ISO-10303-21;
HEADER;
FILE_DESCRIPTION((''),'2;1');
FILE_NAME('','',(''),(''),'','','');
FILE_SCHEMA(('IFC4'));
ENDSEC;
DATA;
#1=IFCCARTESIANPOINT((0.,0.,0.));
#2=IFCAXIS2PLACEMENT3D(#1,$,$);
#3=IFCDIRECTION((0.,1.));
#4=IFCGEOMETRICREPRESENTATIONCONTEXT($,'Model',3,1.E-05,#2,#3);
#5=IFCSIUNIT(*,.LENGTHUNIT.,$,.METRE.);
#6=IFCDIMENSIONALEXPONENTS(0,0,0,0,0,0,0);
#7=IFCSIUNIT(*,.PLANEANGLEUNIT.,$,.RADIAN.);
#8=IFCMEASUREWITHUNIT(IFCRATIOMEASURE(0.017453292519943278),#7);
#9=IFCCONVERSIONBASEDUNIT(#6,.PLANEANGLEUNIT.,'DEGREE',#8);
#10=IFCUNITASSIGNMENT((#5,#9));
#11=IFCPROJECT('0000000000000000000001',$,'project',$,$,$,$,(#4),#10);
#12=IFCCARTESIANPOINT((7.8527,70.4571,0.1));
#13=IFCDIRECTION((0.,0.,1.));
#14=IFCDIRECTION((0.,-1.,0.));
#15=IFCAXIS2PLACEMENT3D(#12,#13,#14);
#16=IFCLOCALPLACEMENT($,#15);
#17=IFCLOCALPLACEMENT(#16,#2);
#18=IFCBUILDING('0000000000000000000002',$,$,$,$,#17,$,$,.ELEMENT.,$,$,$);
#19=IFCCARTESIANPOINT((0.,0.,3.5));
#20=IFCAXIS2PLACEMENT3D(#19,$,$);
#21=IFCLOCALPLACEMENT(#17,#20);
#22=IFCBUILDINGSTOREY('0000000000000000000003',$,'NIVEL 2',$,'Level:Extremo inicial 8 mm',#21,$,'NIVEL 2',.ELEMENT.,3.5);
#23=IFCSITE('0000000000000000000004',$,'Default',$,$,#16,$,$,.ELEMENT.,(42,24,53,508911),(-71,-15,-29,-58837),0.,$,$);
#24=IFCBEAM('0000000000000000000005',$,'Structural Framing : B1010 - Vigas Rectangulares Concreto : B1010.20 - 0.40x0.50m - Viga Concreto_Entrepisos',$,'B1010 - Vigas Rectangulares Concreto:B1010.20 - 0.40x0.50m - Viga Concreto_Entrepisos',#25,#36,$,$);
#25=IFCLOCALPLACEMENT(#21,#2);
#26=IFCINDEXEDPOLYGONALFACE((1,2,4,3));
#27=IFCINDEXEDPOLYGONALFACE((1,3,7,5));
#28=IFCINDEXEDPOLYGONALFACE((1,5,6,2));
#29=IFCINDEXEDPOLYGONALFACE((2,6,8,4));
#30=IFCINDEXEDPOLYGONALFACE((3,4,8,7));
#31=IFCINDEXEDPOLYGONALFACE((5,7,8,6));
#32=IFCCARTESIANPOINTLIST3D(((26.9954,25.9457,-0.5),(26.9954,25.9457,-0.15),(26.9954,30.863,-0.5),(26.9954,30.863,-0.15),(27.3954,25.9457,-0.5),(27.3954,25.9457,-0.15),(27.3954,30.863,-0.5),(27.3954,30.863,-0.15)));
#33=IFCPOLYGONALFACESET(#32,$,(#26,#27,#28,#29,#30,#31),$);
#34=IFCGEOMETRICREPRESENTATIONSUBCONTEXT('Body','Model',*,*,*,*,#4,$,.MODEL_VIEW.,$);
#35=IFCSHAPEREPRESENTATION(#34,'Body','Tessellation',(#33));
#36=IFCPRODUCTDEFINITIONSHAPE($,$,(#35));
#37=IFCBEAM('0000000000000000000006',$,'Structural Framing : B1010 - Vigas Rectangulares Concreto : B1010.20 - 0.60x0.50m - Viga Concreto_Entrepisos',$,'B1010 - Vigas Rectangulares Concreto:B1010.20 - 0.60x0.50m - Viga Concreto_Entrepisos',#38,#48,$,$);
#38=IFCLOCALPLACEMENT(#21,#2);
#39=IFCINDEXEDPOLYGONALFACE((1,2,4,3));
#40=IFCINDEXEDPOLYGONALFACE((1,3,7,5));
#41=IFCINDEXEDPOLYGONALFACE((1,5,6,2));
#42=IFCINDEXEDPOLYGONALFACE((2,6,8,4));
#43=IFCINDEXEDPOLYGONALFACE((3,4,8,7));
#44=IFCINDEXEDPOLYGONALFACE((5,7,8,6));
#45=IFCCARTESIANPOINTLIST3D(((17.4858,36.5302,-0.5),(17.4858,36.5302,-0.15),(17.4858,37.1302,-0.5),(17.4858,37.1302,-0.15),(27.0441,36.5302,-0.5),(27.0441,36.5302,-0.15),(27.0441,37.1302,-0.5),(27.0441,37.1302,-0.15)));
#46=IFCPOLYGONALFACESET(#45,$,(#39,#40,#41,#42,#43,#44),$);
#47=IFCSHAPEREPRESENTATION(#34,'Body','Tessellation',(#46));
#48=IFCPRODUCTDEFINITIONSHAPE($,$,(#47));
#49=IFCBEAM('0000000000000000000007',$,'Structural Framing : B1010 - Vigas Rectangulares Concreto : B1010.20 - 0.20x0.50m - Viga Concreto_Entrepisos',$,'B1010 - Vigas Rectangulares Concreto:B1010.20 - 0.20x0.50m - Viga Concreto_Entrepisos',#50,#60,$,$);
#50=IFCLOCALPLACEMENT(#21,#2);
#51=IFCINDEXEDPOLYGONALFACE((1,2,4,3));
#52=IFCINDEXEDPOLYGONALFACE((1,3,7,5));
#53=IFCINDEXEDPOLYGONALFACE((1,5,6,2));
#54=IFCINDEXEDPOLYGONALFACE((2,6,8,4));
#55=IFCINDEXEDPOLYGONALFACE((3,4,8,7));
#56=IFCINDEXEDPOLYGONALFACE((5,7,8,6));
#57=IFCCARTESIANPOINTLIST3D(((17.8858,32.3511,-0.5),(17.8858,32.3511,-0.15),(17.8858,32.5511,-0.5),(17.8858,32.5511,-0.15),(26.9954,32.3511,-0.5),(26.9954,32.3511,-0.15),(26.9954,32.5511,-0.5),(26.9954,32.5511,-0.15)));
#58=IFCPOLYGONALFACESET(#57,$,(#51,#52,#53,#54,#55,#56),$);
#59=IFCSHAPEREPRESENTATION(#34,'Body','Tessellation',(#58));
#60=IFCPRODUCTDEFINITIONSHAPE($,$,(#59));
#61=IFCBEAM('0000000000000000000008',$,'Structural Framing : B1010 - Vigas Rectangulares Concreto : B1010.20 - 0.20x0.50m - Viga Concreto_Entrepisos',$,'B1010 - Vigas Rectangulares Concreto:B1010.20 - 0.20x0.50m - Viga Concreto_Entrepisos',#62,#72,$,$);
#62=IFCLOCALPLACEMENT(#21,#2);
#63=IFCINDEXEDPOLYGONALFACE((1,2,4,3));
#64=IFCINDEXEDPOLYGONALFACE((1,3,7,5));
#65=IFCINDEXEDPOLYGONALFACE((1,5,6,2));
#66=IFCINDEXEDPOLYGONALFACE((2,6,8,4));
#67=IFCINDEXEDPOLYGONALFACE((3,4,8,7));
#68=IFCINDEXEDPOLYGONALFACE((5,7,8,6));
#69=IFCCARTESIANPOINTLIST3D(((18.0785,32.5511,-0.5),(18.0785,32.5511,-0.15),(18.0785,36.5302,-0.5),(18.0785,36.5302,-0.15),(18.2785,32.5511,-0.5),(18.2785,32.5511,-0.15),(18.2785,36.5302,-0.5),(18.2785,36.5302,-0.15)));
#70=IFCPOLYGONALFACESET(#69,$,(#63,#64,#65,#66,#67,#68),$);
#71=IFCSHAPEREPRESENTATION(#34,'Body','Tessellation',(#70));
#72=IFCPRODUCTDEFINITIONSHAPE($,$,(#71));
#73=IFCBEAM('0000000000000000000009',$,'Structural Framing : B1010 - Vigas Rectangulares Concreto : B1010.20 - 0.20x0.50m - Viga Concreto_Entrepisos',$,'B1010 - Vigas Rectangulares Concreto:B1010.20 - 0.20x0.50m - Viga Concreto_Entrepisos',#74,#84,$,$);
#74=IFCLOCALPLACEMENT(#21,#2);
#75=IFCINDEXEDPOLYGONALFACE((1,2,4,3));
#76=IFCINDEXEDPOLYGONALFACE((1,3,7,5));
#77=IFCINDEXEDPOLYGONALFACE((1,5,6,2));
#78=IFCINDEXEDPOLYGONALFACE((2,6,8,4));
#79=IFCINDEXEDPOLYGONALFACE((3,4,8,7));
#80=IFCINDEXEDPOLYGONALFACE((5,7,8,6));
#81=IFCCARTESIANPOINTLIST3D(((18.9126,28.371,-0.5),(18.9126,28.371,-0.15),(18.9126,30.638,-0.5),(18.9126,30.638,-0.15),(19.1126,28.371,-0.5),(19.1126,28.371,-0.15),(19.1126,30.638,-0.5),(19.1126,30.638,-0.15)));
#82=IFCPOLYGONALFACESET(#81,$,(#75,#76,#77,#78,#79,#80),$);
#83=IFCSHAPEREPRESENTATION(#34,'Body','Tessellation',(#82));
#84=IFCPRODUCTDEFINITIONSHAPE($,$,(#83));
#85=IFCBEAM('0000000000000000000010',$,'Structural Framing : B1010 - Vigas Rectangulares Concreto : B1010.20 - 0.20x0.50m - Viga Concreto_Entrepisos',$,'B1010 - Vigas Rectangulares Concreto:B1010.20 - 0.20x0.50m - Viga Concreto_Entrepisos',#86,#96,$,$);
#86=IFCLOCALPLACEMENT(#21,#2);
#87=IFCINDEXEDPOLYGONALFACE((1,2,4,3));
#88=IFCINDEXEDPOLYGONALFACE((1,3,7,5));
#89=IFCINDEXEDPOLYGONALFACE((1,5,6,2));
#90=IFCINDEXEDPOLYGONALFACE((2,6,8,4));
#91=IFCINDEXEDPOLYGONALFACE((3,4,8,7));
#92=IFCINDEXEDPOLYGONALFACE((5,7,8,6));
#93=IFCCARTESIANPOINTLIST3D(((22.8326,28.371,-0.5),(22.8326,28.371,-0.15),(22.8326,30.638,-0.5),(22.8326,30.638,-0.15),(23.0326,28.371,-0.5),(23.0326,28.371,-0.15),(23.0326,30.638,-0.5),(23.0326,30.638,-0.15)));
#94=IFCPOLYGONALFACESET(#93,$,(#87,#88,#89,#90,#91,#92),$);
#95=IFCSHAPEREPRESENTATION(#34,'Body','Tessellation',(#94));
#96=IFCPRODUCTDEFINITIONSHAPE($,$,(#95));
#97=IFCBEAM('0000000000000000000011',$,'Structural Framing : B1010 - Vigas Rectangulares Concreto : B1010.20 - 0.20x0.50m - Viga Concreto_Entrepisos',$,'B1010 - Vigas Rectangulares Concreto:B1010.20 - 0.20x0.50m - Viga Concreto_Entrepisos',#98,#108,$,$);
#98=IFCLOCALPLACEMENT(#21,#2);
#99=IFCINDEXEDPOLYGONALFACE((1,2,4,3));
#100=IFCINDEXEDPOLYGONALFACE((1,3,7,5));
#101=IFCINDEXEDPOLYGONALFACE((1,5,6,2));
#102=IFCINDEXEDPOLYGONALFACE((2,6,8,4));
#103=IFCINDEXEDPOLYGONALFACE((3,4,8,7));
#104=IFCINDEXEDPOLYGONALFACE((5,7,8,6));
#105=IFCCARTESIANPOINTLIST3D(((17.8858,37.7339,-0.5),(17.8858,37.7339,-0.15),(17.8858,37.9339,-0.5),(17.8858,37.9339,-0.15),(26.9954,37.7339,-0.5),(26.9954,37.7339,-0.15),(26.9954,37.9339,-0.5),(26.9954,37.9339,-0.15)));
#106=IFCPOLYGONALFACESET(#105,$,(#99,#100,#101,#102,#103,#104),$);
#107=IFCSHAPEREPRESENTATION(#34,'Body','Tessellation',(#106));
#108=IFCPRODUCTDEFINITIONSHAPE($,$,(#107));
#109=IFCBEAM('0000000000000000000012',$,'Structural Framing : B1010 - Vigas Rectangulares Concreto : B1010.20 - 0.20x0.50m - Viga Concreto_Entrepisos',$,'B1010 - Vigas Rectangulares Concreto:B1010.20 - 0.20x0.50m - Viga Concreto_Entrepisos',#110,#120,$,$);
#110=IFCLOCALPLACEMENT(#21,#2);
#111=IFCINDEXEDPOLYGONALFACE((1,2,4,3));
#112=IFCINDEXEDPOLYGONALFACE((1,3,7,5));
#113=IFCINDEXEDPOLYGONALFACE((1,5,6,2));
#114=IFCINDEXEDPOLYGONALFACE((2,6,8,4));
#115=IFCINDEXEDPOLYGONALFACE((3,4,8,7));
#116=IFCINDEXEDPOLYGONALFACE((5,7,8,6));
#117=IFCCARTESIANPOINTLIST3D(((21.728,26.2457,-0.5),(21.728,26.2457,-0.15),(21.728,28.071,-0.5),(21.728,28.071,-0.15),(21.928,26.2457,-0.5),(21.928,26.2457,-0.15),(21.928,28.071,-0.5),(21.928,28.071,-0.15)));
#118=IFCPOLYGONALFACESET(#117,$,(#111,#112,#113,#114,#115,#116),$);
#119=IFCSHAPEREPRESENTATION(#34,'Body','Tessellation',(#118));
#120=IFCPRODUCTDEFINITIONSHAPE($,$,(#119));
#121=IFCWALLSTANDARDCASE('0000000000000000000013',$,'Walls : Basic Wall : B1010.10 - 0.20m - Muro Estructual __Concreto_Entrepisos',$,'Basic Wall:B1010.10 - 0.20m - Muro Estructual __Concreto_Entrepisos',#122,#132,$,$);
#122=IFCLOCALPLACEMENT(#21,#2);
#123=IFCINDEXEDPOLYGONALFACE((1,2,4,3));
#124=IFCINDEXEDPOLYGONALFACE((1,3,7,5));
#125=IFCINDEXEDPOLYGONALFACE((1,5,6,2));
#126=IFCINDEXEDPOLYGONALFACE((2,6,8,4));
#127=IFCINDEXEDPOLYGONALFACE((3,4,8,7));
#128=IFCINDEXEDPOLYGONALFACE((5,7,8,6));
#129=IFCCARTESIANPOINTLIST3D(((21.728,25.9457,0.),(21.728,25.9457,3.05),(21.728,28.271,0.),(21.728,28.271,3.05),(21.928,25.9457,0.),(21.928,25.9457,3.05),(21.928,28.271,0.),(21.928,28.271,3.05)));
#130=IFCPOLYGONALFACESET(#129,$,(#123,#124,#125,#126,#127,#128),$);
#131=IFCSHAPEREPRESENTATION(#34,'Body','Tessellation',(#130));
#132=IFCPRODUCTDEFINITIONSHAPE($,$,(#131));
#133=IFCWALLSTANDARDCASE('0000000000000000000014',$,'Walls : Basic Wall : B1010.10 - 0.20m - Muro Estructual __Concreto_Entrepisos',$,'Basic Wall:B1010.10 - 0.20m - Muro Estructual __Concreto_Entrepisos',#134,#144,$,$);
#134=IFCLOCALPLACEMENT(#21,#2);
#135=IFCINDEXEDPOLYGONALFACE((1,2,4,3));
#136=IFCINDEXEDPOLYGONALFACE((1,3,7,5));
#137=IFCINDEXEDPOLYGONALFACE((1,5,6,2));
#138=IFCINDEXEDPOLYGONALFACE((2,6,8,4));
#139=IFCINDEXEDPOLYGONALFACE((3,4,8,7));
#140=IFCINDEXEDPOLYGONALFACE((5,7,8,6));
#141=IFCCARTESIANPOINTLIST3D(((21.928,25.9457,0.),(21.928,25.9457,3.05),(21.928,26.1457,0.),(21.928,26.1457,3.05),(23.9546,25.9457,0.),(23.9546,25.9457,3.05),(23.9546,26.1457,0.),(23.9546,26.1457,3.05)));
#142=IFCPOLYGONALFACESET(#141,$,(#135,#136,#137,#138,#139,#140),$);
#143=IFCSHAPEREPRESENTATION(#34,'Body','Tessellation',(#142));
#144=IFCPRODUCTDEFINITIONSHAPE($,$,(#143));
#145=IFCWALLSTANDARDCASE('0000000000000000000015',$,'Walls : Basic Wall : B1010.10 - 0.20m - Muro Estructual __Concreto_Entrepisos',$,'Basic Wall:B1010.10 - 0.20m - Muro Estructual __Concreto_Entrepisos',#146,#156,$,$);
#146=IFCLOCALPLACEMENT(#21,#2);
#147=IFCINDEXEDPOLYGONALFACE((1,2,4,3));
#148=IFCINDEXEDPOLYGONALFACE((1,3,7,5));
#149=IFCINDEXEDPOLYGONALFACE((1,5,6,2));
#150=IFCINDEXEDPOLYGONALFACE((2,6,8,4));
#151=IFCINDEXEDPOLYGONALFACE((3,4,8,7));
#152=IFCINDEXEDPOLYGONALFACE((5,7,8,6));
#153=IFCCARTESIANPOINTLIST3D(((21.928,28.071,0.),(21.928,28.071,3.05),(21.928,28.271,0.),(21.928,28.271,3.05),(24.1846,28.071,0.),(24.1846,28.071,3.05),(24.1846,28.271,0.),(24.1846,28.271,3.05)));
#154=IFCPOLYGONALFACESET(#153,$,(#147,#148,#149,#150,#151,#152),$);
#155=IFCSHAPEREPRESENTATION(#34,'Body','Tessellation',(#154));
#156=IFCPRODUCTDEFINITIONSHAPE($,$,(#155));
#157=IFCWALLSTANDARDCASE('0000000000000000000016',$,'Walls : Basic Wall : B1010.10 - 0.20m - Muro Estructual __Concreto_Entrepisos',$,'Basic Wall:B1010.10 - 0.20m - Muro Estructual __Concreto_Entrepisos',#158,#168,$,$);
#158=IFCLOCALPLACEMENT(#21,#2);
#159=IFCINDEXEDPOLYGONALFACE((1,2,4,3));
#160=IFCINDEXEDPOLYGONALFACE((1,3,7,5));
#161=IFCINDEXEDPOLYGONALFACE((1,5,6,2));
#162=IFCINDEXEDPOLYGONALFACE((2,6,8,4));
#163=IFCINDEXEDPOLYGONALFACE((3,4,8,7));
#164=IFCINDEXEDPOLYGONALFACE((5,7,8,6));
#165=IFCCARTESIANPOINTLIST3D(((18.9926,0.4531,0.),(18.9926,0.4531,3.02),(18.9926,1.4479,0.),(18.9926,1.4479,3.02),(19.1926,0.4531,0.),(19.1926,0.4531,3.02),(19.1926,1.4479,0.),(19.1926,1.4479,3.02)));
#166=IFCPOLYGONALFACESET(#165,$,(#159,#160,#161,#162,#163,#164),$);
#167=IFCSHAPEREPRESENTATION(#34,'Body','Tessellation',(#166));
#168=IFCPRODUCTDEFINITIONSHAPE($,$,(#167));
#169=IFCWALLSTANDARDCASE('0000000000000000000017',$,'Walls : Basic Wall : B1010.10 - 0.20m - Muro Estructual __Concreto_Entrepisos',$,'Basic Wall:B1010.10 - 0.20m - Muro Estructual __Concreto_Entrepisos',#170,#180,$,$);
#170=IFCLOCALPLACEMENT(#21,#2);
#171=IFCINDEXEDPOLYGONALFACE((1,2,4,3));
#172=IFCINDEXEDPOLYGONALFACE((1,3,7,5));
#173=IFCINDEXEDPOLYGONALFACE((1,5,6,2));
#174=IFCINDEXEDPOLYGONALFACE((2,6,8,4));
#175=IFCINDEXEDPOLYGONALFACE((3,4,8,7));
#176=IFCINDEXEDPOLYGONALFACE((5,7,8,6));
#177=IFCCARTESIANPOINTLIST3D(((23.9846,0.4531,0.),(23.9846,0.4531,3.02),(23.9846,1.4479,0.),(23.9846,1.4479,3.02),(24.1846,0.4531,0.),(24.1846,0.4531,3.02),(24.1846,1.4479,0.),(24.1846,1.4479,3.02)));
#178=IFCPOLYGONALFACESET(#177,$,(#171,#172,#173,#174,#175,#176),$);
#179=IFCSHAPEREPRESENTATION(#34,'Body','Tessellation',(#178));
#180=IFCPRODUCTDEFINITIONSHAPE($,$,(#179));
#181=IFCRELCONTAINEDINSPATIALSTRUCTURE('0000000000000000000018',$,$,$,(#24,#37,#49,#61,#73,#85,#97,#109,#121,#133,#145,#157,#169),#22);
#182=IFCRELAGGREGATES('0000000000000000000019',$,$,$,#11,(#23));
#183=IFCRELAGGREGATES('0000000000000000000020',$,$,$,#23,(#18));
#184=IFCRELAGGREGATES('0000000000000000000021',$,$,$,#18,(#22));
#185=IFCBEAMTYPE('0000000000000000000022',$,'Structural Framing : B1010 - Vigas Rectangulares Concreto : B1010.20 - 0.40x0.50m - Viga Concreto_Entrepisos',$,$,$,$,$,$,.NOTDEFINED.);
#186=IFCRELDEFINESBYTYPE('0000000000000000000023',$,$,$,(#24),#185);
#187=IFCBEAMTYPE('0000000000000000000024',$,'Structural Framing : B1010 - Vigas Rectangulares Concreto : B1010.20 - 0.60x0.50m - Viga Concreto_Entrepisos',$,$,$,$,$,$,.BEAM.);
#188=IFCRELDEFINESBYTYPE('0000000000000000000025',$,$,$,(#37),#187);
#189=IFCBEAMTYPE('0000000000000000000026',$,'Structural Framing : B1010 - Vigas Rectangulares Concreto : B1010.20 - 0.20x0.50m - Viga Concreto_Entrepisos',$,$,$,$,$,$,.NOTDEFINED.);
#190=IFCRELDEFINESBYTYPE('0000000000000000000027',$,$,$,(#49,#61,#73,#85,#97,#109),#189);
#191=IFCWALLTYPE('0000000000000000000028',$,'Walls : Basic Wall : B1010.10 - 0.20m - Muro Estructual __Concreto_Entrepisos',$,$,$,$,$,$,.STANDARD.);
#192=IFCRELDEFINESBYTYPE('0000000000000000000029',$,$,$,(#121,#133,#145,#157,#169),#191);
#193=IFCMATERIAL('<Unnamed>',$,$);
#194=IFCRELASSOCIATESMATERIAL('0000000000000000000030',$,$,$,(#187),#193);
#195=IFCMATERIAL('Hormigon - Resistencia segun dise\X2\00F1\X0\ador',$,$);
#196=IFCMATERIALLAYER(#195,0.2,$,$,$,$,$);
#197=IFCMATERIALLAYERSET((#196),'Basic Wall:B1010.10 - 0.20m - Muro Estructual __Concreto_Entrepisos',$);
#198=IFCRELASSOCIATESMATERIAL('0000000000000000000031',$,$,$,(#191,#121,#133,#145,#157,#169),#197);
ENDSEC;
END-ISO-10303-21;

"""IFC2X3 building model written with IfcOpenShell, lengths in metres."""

from ifc_helpers import new_model, entity, si_unit, converted_unit, direction, frame, frame_2d, origin, place, context, subcontext, project, spatial, rectangle, extrude, material, layer, layer_set, layer_usage, type_object, element, save


model = new_model("IFC2X3")

# Units and contexts
model_context = context("Model", 3, precision=1e-05, world=origin(), true_north=direction((0.0, 1.0)))
body_context = subcontext(model_context, "Body", "Model", "MODEL_VIEW")
ifc_project = project(units=[si_unit("LENGTHUNIT", "METRE"), converted_unit("PLANEANGLEUNIT", "DEGREE", entity("IfcRatioMeasure", 0.017453292519943278), si_unit("PLANEANGLEUNIT", "RADIAN"), dimensions=[0, 0, 0, 0, 0, 0, 0])], contexts=[model_context])

# Site, building, storey
site_placement = place(None, frame((7.8527, 70.4571, 0.1), z_axis=(0.0, 0.0, 1.0), x_axis=(0.0, -1.0, 0.0)))
site = spatial("IfcSite", under=ifc_project, at=site_placement, Name="Default", CompositionType="ELEMENT", RefLatitude=(42, 24, 53, 508911), RefLongitude=(-71, -15, -29, -58837), RefElevation=0.0)
building_placement = place(site_placement, origin())
building = spatial("IfcBuilding", under=site, at=building_placement, CompositionType="ELEMENT")
storey_placement = place(building_placement, frame((0.0, 0.0, 3.5)))
storey = spatial("IfcBuildingStorey", under=building, at=storey_placement, Name="NIVEL 2", ObjectType="Level:Extremo inicial 8 mm", LongName="NIVEL 2", CompositionType="ELEMENT", Elevation=3.5)

# Beams
beam_type_1 = type_object("IfcBeamType", Name="Structural Framing : B1010 - Vigas Rectangulares Concreto : B1010.20 - 0.40x0.50m - Viga Concreto_Entrepisos", PredefinedType="NOTDEFINED")
beam_1_placement = place(storey_placement, frame((27.1954, 26.0957, 0.0), z_axis=(0.0, 0.0, 1.0), x_axis=(0.0, 1.0, 0.0)))
element("IfcBeam", 1, at=beam_1_placement, inside=storey, type_object=beam_type_1, Name="Structural Framing : B1010 - Vigas Rectangulares Concreto : B1010.20 - 0.40x0.50m - Viga Concreto_Entrepisos", ObjectType="B1010 - Vigas Rectangulares Concreto:B1010.20 - 0.40x0.50m - Viga Concreto_Entrepisos", context=body_context, shape_type="SweptSolid", body=[
    extrude(rectangle(XDim=0.35, YDim=0.4, at=frame_2d((0.0, 0.0), x_axis=(1.0, 0.0))), frame((-0.15, 0.0, -0.325), z_axis=(1.0, 0.0, 0.0), x_axis=(0.0, 0.0, -1.0)), (0.0, 0.0, 1.0), 4.9174),
])
ifc_material_1 = material(Name="<Unnamed>")
beam_type_2 = type_object("IfcBeamType", Name="Structural Framing : B1010 - Vigas Rectangulares Concreto : B1010.20 - 0.60x0.50m - Viga Concreto_Entrepisos", PredefinedType="BEAM", material=ifc_material_1)
beam_2_placement = place(storey_placement, frame((17.4858, 36.8302, 0.0)))
element("IfcBeam", 2, at=beam_2_placement, inside=storey, type_object=beam_type_2, Name="Structural Framing : B1010 - Vigas Rectangulares Concreto : B1010.20 - 0.60x0.50m - Viga Concreto_Entrepisos", ObjectType="B1010 - Vigas Rectangulares Concreto:B1010.20 - 0.60x0.50m - Viga Concreto_Entrepisos", context=body_context, shape_type="SweptSolid", body=[
    extrude(rectangle(XDim=0.35, YDim=0.6, at=frame_2d((0.0, 0.0), x_axis=(1.0, 0.0))), frame((0.0, 0.0, -0.325), z_axis=(1.0, 0.0, 0.0), x_axis=(0.0, 0.0, -1.0)), (0.0, 0.0, 1.0), 9.5583),
])
beam_type_3 = type_object("IfcBeamType", Name="Structural Framing : B1010 - Vigas Rectangulares Concreto : B1010.20 - 0.20x0.50m - Viga Concreto_Entrepisos", PredefinedType="NOTDEFINED")
beam_3_placement = place(storey_placement, frame((17.6858, 32.4511, 0.0)))
element("IfcBeam", 3, at=beam_3_placement, inside=storey, type_object=beam_type_3, Name="Structural Framing : B1010 - Vigas Rectangulares Concreto : B1010.20 - 0.20x0.50m - Viga Concreto_Entrepisos", ObjectType="B1010 - Vigas Rectangulares Concreto:B1010.20 - 0.20x0.50m - Viga Concreto_Entrepisos", context=body_context, shape_type="SweptSolid", body=[
    extrude(rectangle(XDim=0.35, YDim=0.2, at=frame_2d((0.0, 0.0), x_axis=(1.0, 0.0))), frame((0.2, 0.0, -0.325), z_axis=(1.0, 0.0, 0.0), x_axis=(0.0, 0.0, -1.0)), (0.0, 0.0, 1.0), 9.1096),
])
beam_4_placement = place(storey_placement, frame((18.1785, 32.4511, 0.0), z_axis=(0.0, 0.0, 1.0), x_axis=(0.0, 1.0, 0.0)))
element("IfcBeam", 4, at=beam_4_placement, inside=storey, type_object=beam_type_3, Name="Structural Framing : B1010 - Vigas Rectangulares Concreto : B1010.20 - 0.20x0.50m - Viga Concreto_Entrepisos", ObjectType="B1010 - Vigas Rectangulares Concreto:B1010.20 - 0.20x0.50m - Viga Concreto_Entrepisos", context=body_context, shape_type="SweptSolid", body=[
    extrude(rectangle(XDim=0.35, YDim=0.2, at=frame_2d((0.0, 0.0), x_axis=(1.0, 0.0))), frame((0.1, 0.0, -0.325), z_axis=(1.0, 0.0, 0.0), x_axis=(0.0, 0.0, -1.0)), (0.0, 0.0, 1.0), 3.9792),
])
beam_5_placement = place(storey_placement, frame((19.0126, 28.221, 0.0), z_axis=(0.0, 0.0, 1.0), x_axis=(0.0, 1.0, 0.0)))
element("IfcBeam", 5, at=beam_5_placement, inside=storey, type_object=beam_type_3, Name="Structural Framing : B1010 - Vigas Rectangulares Concreto : B1010.20 - 0.20x0.50m - Viga Concreto_Entrepisos", ObjectType="B1010 - Vigas Rectangulares Concreto:B1010.20 - 0.20x0.50m - Viga Concreto_Entrepisos", context=body_context, shape_type="SweptSolid", body=[
    extrude(rectangle(XDim=0.35, YDim=0.2, at=frame_2d((0.0, 0.0), x_axis=(1.0, 0.0))), frame((0.15, 0.0, -0.325), z_axis=(1.0, 0.0, 0.0), x_axis=(0.0, 0.0, -1.0)), (0.0, 0.0, 1.0), 2.2671),
])
beam_6_placement = place(storey_placement, frame((22.9326, 28.171, 0.0), z_axis=(0.0, 0.0, 1.0), x_axis=(0.0, 1.0, 0.0)))
element("IfcBeam", 6, at=beam_6_placement, inside=storey, type_object=beam_type_3, Name="Structural Framing : B1010 - Vigas Rectangulares Concreto : B1010.20 - 0.20x0.50m - Viga Concreto_Entrepisos", ObjectType="B1010 - Vigas Rectangulares Concreto:B1010.20 - 0.20x0.50m - Viga Concreto_Entrepisos", context=body_context, shape_type="SweptSolid", body=[
    extrude(rectangle(XDim=0.35, YDim=0.2, at=frame_2d((0.0, 0.0), x_axis=(1.0, 0.0))), frame((0.2, 0.0, -0.325), z_axis=(1.0, 0.0, 0.0), x_axis=(0.0, 0.0, -1.0)), (0.0, 0.0, 1.0), 2.2671),
])
beam_7_placement = place(storey_placement, frame((17.6858, 37.8339, 0.0)))
element("IfcBeam", 7, at=beam_7_placement, inside=storey, type_object=beam_type_3, Name="Structural Framing : B1010 - Vigas Rectangulares Concreto : B1010.20 - 0.20x0.50m - Viga Concreto_Entrepisos", ObjectType="B1010 - Vigas Rectangulares Concreto:B1010.20 - 0.20x0.50m - Viga Concreto_Entrepisos", context=body_context, shape_type="SweptSolid", body=[
    extrude(rectangle(XDim=0.35, YDim=0.2, at=frame_2d((0.0, 0.0), x_axis=(1.0, 0.0))), frame((0.2, 0.0, -0.325), z_axis=(1.0, 0.0, 0.0), x_axis=(0.0, 0.0, -1.0)), (0.0, 0.0, 1.0), 9.1096),
])
beam_8_placement = place(storey_placement, frame((21.828, 26.0957, 0.0), z_axis=(0.0, 0.0, 1.0), x_axis=(0.0, 1.0, 0.0)))
element("IfcBeam", 8, at=beam_8_placement, inside=storey, type_object=beam_type_3, Name="Structural Framing : B1010 - Vigas Rectangulares Concreto : B1010.20 - 0.20x0.50m - Viga Concreto_Entrepisos", ObjectType="B1010 - Vigas Rectangulares Concreto:B1010.20 - 0.20x0.50m - Viga Concreto_Entrepisos", context=body_context, shape_type="SweptSolid", body=[
    extrude(rectangle(XDim=0.35, YDim=0.2, at=frame_2d((0.0, 0.0), x_axis=(1.0, 0.0))), frame((0.15, 0.0, -0.325), z_axis=(1.0, 0.0, 0.0), x_axis=(0.0, 0.0, -1.0)), (0.0, 0.0, 1.0), 1.8253),
])

# Walls
ifc_material_2 = material(Name="Hormigon - Resistencia segun diseñador")
ifc_layer = layer(ifc_material_2, 0.2)
ifc_layer_set = layer_set([ifc_layer], Name="Basic Wall:B1010.10 - 0.20m - Muro Estructual __Concreto_Entrepisos")
ifc_layer_usage_1 = layer_usage(ifc_layer_set, "AXIS2", "NEGATIVE", 0.1)
wall_type = type_object("IfcWallType", Name="Walls : Basic Wall : B1010.10 - 0.20m - Muro Estructual __Concreto_Entrepisos", PredefinedType="STANDARD", material=ifc_layer_set)
wall_1_placement = place(storey_placement, frame((21.828, 25.9457, 0.0), z_axis=(0.0, 0.0, 1.0), x_axis=(0.0, 1.0, 0.0)))
element("IfcWallStandardCase", 9, at=wall_1_placement, inside=storey, type_object=wall_type, material=ifc_layer_usage_1, Name="Walls : Basic Wall : B1010.10 - 0.20m - Muro Estructual __Concreto_Entrepisos", ObjectType="Basic Wall:B1010.10 - 0.20m - Muro Estructual __Concreto_Entrepisos", context=body_context, shape_type="SweptSolid", body=[
    extrude(rectangle(XDim=2.3253, YDim=0.2, at=frame_2d((1.1626, 0.0), x_axis=(-1.0, 0.0))), origin(), (0.0, 0.0, 1.0), 3.05),
])
ifc_layer_usage_2 = layer_usage(ifc_layer_set, "AXIS2", "NEGATIVE", 0.1)
wall_2_placement = place(storey_placement, frame((21.928, 26.0457, 0.0)))
element("IfcWallStandardCase", 10, at=wall_2_placement, inside=storey, type_object=wall_type, material=ifc_layer_usage_2, Name="Walls : Basic Wall : B1010.10 - 0.20m - Muro Estructual __Concreto_Entrepisos", ObjectType="Basic Wall:B1010.10 - 0.20m - Muro Estructual __Concreto_Entrepisos", context=body_context, shape_type="SweptSolid", body=[
    extrude(rectangle(XDim=2.0266, YDim=0.2, at=frame_2d((1.0133, 0.0), x_axis=(-1.0, 0.0))), origin(), (0.0, 0.0, 1.0), 3.05),
])
ifc_layer_usage_3 = layer_usage(ifc_layer_set, "AXIS2", "NEGATIVE", 0.1)
wall_3_placement = place(storey_placement, frame((21.928, 28.171, 0.0)))
element("IfcWallStandardCase", 11, at=wall_3_placement, inside=storey, type_object=wall_type, material=ifc_layer_usage_3, Name="Walls : Basic Wall : B1010.10 - 0.20m - Muro Estructual __Concreto_Entrepisos", ObjectType="Basic Wall:B1010.10 - 0.20m - Muro Estructual __Concreto_Entrepisos", context=body_context, shape_type="SweptSolid", body=[
    extrude(rectangle(XDim=2.2566, YDim=0.2, at=frame_2d((1.1283, 0.0), x_axis=(-1.0, 0.0))), origin(), (0.0, 0.0, 1.0), 3.05),
])
ifc_layer_usage_4 = layer_usage(ifc_layer_set, "AXIS2", "NEGATIVE", 0.1)
wall_4_placement = place(storey_placement, frame((19.0926, 0.4531, 0.0), z_axis=(0.0, 0.0, 1.0), x_axis=(0.0, 1.0, 0.0)))
element("IfcWallStandardCase", 12, at=wall_4_placement, inside=storey, type_object=wall_type, material=ifc_layer_usage_4, Name="Walls : Basic Wall : B1010.10 - 0.20m - Muro Estructual __Concreto_Entrepisos", ObjectType="Basic Wall:B1010.10 - 0.20m - Muro Estructual __Concreto_Entrepisos", context=body_context, shape_type="SweptSolid", body=[
    extrude(rectangle(XDim=0.9948, YDim=0.2, at=frame_2d((0.4974, 0.0), x_axis=(-1.0, 0.0))), origin(), (0.0, 0.0, 1.0), 3.02),
])
ifc_layer_usage_5 = layer_usage(ifc_layer_set, "AXIS2", "NEGATIVE", 0.1)
wall_5_placement = place(storey_placement, frame((24.0846, 0.4531, 0.0), z_axis=(0.0, 0.0, 1.0), x_axis=(0.0, 1.0, 0.0)))
element("IfcWallStandardCase", 13, at=wall_5_placement, inside=storey, type_object=wall_type, material=ifc_layer_usage_5, Name="Walls : Basic Wall : B1010.10 - 0.20m - Muro Estructual __Concreto_Entrepisos", ObjectType="Basic Wall:B1010.10 - 0.20m - Muro Estructual __Concreto_Entrepisos", context=body_context, shape_type="SweptSolid", body=[
    extrude(rectangle(XDim=0.9948, YDim=0.2, at=frame_2d((0.4974, 0.0), x_axis=(-1.0, 0.0))), origin(), (0.0, 0.0, 1.0), 3.02),
])

save(model, "model.ifc")
